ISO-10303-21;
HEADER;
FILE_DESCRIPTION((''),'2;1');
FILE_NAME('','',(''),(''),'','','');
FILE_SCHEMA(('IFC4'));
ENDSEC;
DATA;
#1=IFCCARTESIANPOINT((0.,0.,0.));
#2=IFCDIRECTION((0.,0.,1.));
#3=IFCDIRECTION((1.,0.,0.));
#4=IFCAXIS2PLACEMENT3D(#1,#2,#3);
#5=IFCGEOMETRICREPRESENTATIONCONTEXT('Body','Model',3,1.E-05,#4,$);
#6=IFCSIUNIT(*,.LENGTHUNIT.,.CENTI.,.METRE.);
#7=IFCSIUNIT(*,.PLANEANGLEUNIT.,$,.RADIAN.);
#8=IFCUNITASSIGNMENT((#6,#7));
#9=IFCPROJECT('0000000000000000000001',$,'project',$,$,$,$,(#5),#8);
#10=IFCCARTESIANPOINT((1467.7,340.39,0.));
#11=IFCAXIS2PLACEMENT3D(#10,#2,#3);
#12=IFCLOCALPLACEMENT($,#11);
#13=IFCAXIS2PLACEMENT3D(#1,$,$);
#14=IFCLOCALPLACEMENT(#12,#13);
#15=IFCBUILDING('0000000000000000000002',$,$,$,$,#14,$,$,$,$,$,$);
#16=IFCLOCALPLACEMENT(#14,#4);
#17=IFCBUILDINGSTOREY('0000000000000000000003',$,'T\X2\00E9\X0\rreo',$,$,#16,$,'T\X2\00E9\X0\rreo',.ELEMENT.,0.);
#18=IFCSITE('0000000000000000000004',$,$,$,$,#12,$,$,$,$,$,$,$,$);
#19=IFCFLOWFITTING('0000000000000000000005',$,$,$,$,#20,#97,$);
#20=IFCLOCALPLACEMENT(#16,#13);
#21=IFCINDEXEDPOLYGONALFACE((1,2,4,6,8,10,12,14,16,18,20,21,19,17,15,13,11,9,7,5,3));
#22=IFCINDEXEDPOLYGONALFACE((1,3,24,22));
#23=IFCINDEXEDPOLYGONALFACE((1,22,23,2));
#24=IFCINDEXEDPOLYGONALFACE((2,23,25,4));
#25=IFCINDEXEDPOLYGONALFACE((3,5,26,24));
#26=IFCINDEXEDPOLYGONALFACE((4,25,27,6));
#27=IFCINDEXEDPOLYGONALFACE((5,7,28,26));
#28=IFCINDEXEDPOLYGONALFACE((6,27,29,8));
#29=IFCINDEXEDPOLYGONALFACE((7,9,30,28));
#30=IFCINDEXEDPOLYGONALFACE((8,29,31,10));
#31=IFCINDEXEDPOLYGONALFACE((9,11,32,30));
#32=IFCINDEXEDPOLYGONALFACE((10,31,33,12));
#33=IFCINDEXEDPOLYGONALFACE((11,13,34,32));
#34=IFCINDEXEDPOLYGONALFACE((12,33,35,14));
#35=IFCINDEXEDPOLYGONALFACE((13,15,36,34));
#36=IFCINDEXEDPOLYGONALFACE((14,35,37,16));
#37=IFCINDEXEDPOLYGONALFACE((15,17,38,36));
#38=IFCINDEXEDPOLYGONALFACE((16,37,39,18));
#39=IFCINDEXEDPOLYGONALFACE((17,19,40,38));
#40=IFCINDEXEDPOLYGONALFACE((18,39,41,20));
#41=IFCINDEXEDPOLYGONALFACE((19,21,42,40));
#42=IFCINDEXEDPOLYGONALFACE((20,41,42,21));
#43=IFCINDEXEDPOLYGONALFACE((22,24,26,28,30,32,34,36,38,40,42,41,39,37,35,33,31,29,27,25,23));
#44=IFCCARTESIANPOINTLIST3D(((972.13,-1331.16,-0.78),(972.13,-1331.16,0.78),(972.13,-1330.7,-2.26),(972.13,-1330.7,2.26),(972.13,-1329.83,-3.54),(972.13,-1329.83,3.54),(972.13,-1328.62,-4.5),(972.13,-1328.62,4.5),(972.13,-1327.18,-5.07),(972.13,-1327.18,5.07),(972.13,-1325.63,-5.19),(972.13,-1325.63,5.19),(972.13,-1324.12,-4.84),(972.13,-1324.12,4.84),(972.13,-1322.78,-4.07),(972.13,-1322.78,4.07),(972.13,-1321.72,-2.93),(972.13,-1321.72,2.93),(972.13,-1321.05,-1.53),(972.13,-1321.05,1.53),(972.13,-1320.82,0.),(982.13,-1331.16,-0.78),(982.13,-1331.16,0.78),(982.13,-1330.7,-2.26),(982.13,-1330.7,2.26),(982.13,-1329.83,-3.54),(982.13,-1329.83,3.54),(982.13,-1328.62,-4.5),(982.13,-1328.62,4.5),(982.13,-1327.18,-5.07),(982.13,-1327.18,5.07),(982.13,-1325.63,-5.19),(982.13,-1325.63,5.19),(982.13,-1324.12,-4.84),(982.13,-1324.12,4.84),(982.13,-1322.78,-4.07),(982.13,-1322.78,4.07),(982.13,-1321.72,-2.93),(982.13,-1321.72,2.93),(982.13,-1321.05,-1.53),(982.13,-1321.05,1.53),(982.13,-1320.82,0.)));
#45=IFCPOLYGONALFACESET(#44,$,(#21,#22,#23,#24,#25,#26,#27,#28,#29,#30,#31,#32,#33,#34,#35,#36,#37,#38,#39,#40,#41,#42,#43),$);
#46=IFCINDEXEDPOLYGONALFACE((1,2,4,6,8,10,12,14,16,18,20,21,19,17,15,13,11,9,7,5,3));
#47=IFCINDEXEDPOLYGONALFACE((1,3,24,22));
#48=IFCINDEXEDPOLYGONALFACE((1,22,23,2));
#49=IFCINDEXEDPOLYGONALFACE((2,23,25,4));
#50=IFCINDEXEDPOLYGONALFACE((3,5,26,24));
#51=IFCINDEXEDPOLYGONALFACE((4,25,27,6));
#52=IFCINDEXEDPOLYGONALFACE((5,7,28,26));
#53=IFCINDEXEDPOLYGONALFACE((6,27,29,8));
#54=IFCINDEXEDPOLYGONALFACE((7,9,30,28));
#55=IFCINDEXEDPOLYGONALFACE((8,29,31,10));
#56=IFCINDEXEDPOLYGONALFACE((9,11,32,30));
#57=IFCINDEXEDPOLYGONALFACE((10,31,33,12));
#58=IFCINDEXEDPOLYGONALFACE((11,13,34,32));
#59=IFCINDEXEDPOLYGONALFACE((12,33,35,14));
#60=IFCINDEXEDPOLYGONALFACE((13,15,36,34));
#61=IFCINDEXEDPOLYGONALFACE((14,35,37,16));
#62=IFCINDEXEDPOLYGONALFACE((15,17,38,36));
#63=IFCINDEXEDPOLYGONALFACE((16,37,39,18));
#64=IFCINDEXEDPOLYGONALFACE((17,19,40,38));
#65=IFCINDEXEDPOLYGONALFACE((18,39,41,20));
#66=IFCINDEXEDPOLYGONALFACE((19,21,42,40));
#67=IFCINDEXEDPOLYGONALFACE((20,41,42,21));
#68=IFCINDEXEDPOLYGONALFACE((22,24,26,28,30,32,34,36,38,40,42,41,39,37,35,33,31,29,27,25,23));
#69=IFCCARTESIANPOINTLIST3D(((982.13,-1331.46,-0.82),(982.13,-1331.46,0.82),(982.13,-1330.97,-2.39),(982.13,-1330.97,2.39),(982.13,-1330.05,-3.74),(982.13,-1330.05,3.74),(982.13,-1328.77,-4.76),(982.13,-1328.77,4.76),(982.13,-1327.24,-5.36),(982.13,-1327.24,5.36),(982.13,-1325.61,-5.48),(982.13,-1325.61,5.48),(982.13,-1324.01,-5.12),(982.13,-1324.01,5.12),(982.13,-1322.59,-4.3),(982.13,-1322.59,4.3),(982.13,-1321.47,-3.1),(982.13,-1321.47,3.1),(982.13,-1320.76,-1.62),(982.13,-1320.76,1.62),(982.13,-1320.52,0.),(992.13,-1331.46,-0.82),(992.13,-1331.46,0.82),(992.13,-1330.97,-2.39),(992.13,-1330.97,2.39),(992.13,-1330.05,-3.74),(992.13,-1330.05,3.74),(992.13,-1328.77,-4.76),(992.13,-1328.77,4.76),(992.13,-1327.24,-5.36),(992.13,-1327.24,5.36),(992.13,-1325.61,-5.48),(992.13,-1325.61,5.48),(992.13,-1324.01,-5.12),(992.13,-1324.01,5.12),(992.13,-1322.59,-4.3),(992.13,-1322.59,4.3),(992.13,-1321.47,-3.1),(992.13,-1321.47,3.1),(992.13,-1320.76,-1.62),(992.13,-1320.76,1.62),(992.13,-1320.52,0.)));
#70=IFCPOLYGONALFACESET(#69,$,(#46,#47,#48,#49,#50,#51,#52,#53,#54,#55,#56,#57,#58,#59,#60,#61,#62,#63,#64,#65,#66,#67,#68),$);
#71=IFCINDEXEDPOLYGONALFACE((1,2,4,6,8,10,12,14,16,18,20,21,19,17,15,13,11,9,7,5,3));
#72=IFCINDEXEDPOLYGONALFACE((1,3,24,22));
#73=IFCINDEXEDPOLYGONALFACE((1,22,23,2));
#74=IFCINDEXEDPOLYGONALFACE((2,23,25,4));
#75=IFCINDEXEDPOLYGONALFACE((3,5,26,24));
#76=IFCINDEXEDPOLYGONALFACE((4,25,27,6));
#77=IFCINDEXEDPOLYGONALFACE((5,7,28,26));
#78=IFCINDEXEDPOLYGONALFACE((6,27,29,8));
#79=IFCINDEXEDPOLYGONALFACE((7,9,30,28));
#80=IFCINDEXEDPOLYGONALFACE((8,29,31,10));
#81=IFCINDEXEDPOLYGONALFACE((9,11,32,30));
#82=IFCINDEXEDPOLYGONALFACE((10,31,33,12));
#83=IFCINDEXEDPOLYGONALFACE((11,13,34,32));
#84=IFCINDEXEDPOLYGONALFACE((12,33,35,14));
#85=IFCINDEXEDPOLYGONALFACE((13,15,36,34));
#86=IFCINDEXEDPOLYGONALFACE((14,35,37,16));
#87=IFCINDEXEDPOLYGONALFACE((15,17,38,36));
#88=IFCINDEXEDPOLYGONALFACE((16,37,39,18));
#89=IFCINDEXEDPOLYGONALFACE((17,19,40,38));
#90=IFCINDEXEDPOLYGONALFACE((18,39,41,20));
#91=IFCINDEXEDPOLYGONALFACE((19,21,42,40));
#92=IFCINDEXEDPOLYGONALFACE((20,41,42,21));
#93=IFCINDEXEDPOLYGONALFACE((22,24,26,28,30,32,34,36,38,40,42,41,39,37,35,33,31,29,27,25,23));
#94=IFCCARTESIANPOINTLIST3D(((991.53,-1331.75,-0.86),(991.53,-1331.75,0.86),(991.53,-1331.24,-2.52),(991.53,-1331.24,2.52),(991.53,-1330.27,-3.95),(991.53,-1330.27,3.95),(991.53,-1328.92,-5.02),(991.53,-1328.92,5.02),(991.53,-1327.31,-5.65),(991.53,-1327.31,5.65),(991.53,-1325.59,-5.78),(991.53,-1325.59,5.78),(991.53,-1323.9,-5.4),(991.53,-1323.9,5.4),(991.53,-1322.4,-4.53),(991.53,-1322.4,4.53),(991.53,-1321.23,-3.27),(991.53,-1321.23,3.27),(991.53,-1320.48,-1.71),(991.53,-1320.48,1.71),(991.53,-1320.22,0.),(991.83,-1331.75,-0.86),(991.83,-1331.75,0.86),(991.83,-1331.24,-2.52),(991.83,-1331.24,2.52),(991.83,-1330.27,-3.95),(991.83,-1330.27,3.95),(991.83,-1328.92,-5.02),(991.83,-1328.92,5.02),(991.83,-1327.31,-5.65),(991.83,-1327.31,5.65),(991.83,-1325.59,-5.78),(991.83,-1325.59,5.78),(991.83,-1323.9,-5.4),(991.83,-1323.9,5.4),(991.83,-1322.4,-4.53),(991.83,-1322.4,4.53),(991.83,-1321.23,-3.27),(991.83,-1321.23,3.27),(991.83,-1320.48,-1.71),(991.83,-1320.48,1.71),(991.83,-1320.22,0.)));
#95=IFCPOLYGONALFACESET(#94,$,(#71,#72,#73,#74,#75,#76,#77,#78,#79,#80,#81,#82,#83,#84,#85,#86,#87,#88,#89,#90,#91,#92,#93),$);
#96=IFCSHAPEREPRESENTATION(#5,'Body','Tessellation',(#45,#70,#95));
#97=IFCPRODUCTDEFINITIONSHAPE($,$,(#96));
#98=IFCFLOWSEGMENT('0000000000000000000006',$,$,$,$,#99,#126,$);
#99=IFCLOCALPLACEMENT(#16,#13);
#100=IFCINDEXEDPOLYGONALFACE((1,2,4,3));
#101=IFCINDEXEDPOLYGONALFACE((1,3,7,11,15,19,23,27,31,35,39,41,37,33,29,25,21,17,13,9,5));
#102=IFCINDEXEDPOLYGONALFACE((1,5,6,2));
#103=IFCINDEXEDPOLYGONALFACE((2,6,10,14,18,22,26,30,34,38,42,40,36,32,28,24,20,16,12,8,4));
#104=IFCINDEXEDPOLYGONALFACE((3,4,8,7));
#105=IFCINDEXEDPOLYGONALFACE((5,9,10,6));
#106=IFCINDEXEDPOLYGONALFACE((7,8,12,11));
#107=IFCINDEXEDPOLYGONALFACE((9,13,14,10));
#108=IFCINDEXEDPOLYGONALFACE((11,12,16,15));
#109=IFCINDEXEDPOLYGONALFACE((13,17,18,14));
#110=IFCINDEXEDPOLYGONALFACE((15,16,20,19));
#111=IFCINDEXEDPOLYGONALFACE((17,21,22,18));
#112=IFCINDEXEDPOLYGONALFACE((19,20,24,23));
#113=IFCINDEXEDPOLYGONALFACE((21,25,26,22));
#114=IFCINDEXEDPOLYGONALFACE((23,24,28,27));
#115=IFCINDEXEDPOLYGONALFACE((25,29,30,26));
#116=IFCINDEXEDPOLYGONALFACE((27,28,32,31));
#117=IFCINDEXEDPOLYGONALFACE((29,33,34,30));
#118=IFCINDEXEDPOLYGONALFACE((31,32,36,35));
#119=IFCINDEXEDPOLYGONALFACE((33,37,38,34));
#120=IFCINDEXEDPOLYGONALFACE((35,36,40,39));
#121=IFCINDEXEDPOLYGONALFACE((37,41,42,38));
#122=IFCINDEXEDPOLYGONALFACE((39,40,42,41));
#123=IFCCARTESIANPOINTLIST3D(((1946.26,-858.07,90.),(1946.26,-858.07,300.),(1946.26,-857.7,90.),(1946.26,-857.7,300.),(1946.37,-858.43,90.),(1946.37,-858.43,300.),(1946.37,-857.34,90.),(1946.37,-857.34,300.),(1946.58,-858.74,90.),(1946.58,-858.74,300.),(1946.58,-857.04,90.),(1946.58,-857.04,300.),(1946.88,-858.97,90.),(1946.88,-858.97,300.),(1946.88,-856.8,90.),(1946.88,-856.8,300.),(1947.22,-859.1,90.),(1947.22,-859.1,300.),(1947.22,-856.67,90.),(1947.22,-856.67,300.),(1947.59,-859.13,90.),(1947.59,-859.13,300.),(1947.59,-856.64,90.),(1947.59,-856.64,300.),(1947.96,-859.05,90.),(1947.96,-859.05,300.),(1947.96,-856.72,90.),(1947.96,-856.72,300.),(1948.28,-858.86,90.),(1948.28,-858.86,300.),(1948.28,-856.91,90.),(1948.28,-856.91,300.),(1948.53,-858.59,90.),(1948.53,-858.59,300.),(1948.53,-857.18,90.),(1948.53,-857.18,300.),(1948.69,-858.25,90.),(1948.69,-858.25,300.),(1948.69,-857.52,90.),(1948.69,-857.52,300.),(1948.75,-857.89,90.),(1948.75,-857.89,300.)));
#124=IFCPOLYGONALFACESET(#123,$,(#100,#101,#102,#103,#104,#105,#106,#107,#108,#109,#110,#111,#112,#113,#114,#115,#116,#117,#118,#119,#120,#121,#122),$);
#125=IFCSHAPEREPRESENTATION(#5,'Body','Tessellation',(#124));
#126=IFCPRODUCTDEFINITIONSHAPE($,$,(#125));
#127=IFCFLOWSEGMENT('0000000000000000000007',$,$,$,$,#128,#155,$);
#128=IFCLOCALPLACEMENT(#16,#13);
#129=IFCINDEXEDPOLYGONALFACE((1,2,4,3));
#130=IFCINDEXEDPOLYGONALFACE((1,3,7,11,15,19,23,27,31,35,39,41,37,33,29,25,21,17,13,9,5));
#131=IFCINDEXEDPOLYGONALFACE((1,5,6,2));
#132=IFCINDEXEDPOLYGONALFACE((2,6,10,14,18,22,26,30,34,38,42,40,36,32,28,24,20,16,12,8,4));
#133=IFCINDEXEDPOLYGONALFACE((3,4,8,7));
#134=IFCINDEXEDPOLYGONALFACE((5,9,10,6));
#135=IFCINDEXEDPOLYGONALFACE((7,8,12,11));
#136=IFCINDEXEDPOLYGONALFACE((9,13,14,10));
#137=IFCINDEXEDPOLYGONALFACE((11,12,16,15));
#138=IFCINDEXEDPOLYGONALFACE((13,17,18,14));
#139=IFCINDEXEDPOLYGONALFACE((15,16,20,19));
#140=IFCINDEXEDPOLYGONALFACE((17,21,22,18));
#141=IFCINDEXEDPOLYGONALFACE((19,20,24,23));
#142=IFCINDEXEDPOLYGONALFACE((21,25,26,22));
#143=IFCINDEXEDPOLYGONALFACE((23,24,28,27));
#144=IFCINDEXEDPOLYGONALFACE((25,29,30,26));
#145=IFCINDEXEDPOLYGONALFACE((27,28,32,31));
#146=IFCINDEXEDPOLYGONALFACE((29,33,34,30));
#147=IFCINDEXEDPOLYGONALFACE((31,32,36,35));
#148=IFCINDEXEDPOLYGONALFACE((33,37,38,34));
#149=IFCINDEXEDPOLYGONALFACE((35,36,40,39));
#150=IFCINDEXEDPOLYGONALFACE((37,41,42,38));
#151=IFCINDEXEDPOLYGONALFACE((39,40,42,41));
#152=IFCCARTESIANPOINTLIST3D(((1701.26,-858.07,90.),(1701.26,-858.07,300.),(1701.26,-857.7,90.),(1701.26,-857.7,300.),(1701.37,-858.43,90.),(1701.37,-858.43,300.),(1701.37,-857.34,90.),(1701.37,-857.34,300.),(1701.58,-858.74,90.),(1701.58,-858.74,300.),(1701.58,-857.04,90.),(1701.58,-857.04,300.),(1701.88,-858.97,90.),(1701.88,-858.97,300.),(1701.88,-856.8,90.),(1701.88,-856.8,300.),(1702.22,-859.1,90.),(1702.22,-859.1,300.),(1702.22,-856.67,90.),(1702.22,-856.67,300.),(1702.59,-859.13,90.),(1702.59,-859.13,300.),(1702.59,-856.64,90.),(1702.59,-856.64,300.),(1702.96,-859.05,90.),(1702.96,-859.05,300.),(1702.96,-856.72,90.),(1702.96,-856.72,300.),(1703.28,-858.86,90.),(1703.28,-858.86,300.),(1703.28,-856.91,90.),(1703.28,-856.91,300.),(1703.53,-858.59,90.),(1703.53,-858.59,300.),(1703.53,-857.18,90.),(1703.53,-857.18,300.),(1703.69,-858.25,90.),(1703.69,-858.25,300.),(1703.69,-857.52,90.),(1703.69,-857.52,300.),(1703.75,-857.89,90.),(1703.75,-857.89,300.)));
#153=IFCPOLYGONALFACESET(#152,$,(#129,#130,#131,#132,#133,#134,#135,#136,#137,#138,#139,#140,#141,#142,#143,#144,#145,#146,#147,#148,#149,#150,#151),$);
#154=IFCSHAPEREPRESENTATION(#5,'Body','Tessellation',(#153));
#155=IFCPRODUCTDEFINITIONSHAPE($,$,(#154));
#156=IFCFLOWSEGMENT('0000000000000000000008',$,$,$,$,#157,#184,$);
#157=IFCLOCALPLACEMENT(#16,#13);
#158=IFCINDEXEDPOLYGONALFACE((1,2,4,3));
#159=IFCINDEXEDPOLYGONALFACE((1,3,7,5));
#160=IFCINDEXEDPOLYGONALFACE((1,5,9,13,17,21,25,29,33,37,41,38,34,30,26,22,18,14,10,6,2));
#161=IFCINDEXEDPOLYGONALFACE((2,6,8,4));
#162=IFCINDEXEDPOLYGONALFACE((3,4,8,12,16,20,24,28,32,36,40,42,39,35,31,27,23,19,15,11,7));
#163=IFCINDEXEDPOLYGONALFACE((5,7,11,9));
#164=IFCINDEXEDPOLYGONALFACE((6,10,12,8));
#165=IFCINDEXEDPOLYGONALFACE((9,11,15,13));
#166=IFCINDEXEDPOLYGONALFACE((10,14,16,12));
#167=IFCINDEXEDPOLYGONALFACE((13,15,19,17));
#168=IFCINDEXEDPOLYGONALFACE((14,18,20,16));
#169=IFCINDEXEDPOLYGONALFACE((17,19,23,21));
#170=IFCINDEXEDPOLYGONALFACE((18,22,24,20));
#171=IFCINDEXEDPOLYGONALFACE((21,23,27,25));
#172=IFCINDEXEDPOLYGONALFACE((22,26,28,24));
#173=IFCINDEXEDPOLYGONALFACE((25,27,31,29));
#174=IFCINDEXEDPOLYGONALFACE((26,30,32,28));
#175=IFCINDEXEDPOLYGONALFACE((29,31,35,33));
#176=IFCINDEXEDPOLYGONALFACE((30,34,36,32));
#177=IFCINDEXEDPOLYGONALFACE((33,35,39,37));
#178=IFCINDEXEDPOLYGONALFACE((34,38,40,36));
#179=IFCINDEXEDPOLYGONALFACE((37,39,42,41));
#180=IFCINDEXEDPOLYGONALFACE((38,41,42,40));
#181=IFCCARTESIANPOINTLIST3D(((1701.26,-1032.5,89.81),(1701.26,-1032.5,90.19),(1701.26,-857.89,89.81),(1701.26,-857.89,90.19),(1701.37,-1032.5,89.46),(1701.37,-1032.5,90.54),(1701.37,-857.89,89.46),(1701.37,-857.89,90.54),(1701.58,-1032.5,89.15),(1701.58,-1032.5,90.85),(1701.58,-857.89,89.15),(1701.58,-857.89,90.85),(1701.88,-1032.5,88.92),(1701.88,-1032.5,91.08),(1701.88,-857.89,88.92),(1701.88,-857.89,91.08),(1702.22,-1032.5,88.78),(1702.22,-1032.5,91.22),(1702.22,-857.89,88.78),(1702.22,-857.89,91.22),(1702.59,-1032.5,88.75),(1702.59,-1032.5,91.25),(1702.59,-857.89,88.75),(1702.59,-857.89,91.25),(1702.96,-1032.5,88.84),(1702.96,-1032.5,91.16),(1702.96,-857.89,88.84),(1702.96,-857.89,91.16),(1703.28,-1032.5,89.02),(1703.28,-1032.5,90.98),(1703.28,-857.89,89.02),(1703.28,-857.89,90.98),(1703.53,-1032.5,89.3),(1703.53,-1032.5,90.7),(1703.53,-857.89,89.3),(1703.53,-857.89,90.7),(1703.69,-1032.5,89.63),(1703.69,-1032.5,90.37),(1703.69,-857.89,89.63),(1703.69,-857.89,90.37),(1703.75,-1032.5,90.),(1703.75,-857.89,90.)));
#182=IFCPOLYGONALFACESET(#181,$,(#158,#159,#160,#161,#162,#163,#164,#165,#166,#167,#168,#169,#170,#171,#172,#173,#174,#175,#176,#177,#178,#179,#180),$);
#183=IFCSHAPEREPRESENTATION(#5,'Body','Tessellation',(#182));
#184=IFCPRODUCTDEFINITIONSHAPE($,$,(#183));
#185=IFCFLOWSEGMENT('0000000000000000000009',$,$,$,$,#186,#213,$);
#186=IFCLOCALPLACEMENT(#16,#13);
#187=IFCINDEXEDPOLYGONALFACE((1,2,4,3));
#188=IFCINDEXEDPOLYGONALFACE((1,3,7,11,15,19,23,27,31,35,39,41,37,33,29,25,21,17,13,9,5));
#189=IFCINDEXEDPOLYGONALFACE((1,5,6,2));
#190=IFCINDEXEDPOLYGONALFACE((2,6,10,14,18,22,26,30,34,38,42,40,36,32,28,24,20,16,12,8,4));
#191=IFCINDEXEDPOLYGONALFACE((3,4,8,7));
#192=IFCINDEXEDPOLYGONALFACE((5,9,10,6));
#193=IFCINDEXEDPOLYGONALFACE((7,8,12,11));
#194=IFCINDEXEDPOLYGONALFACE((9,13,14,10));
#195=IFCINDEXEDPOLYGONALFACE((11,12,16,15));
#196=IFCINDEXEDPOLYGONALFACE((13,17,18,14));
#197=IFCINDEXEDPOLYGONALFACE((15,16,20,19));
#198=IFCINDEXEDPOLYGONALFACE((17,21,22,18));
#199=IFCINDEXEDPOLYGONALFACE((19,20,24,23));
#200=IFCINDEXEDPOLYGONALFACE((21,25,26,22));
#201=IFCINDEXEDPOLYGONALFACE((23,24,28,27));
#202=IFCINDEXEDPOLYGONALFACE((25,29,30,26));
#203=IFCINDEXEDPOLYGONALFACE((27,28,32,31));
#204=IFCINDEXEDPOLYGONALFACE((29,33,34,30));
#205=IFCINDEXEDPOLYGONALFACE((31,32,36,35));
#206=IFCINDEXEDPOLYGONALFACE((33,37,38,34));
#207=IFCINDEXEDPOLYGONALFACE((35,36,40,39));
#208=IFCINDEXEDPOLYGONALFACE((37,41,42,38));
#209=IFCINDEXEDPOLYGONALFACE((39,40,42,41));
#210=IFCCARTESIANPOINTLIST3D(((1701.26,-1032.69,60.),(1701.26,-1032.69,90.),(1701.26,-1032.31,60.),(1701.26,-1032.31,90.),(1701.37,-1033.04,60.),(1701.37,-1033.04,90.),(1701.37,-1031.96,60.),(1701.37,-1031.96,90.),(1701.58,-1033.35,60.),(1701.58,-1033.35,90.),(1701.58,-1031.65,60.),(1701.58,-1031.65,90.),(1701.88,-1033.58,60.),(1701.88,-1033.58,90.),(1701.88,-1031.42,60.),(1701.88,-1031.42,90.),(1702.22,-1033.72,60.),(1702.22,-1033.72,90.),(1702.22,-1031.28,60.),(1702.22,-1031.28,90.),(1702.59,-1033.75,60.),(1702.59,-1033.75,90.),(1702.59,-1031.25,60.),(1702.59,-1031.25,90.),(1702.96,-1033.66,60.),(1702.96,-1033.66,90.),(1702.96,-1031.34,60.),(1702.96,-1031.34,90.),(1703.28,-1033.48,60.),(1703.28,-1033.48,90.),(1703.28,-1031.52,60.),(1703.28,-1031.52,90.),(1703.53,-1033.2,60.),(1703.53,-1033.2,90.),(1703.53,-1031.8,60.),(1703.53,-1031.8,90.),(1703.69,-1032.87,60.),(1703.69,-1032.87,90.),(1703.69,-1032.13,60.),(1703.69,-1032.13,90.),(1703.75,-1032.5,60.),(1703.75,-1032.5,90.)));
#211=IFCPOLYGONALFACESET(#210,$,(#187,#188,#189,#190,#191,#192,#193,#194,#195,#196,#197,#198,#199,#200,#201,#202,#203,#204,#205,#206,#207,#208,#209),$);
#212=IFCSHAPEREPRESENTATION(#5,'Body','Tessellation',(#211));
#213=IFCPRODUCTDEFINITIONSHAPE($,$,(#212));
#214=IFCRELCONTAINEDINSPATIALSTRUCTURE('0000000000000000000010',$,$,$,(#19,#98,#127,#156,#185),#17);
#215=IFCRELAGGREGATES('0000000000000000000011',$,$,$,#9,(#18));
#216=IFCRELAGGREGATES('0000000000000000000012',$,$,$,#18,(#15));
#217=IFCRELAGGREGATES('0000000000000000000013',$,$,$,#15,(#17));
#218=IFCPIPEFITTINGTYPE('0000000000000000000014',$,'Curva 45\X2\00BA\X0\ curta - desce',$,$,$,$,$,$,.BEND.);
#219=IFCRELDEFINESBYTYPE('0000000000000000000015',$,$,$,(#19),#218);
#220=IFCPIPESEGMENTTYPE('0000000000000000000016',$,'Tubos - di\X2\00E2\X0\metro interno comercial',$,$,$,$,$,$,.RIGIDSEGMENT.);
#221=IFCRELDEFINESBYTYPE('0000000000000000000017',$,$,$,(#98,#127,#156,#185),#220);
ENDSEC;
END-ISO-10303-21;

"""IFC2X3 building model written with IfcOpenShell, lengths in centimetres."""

from ifc_helpers import new_model, si_unit, frame, origin, origin_with_axes, origin_2d_with_axis, place, context, project, spatial, circle, extrude, type_object, element, save


model = new_model("IFC2X3")

# Units and contexts
model_context = context("Model", 3, precision=1e-05, world=origin_with_axes(), identifier="Body")
ifc_project = project(units=[si_unit("LENGTHUNIT", "METRE", prefix="CENTI"), si_unit("PLANEANGLEUNIT", "RADIAN")], contexts=[model_context])

# Site, building, storey
site_placement = place(None, frame((1467.7, 340.39, 0.0), z_axis=(0.0, 0.0, 1.0), x_axis=(1.0, 0.0, 0.0)))
site = spatial("IfcSite", under=ifc_project, at=site_placement)
building_placement = place(site_placement, origin())
building = spatial("IfcBuilding", under=site, at=building_placement)
storey_placement = place(building_placement, origin_with_axes())
storey = spatial("IfcBuildingStorey", under=building, at=storey_placement, Name="Térreo", LongName="Térreo", CompositionType="ELEMENT", Elevation=0.0)

# Flow fitting
pipe_fitting_type_1 = type_object("IfcPipeFittingType", Name="Curva 45º curta - desce", PredefinedType="BEND")
flow_fitting_placement = place(storey_placement, frame((982.13, -1326.02, 5.8), z_axis=(0.0, 0.0, 1.0), x_axis=(1.0, 0.0, 0.0)))
element("IfcFlowFitting", 1, at=flow_fitting_placement, inside=storey, type_object=pipe_fitting_type_1, context=model_context, shape_type="SolidModel", body=[
    extrude(circle(Radius=5.2, at=origin_2d_with_axis()), frame((-10.0, 0.0, -5.8), z_axis=(1.0, 0.0, 0.0), x_axis=(0.0, 1.0, 0.0)), (0.0, 0.0, 1.0), 10.0),
    extrude(circle(Radius=5.5, at=origin_2d_with_axis()), frame((0.0, 0.0, -5.8), z_axis=(1.0, 0.0, 0.0), x_axis=(0.0, 1.0, 0.0)), (0.0, 0.0, 1.0), 10.0),
    extrude(circle(Radius=5.8, at=origin_2d_with_axis()), frame((9.4, 0.0, -5.8), z_axis=(1.0, 0.0, 0.0), x_axis=(0.0, 1.0, 0.0)), (0.0, 0.0, 1.0), 0.3),
])

# Flow segments
pipe_segment_type_1 = type_object("IfcPipeSegmentType", Name="Tubos - diâmetro interno comercial", PredefinedType="RIGIDSEGMENT")
for number, where, z_axis, x_axis in (
    (2, (1947.5, -857.89, 300.0), (0.0, 0.0, 1.0), (1.0, 0.0, 0.0)),
    (3, (1702.5, -857.89, 300.0), (0.0, 0.0, 1.0), (1.0, 0.0, 0.0)),
):
    element("IfcFlowSegment", number, at=place(storey_placement, frame(where, z_axis=z_axis, x_axis=x_axis)), inside=storey, type_object=pipe_segment_type_1, context=model_context, shape_type="SolidModel", body=[
        extrude(circle(Radius=1.25, at=origin_2d_with_axis()), frame((0.0, 0.0, 0.0), z_axis=(0.0, 0.0, -1.0), x_axis=(1.0, 0.0, 0.0)), (0.0, 0.0, 1.0), 210.0),
    ])
flow_segment_1_placement = place(storey_placement, frame((1702.5, -945.19, 91.25), z_axis=(0.0, 0.0, 1.0), x_axis=(1.0, 0.0, 0.0)))
element("IfcFlowSegment", 4, at=flow_segment_1_placement, inside=storey, type_object=pipe_segment_type_1, context=model_context, shape_type="SolidModel", body=[
    extrude(circle(Radius=1.25, at=origin_2d_with_axis()), frame((0.0, 87.31, -1.25), z_axis=(0.0, -1.0, 0.0), x_axis=(1.0, 0.0, 0.0)), (0.0, 0.0, 1.0), 174.61),
])
flow_segment_2_placement = place(storey_placement, frame((1702.5, -1032.5, 90.0), z_axis=(0.0, 0.0, 1.0), x_axis=(1.0, 0.0, 0.0)))
element("IfcFlowSegment", 5, at=flow_segment_2_placement, inside=storey, type_object=pipe_segment_type_1, context=model_context, shape_type="SolidModel", body=[
    extrude(circle(Radius=1.25, at=origin_2d_with_axis()), frame((0.0, 0.0, 0.0), z_axis=(0.0, 0.0, -1.0), x_axis=(1.0, 0.0, 0.0)), (0.0, 0.0, 1.0), 30.0),
])

save(model, "model.ifc")
